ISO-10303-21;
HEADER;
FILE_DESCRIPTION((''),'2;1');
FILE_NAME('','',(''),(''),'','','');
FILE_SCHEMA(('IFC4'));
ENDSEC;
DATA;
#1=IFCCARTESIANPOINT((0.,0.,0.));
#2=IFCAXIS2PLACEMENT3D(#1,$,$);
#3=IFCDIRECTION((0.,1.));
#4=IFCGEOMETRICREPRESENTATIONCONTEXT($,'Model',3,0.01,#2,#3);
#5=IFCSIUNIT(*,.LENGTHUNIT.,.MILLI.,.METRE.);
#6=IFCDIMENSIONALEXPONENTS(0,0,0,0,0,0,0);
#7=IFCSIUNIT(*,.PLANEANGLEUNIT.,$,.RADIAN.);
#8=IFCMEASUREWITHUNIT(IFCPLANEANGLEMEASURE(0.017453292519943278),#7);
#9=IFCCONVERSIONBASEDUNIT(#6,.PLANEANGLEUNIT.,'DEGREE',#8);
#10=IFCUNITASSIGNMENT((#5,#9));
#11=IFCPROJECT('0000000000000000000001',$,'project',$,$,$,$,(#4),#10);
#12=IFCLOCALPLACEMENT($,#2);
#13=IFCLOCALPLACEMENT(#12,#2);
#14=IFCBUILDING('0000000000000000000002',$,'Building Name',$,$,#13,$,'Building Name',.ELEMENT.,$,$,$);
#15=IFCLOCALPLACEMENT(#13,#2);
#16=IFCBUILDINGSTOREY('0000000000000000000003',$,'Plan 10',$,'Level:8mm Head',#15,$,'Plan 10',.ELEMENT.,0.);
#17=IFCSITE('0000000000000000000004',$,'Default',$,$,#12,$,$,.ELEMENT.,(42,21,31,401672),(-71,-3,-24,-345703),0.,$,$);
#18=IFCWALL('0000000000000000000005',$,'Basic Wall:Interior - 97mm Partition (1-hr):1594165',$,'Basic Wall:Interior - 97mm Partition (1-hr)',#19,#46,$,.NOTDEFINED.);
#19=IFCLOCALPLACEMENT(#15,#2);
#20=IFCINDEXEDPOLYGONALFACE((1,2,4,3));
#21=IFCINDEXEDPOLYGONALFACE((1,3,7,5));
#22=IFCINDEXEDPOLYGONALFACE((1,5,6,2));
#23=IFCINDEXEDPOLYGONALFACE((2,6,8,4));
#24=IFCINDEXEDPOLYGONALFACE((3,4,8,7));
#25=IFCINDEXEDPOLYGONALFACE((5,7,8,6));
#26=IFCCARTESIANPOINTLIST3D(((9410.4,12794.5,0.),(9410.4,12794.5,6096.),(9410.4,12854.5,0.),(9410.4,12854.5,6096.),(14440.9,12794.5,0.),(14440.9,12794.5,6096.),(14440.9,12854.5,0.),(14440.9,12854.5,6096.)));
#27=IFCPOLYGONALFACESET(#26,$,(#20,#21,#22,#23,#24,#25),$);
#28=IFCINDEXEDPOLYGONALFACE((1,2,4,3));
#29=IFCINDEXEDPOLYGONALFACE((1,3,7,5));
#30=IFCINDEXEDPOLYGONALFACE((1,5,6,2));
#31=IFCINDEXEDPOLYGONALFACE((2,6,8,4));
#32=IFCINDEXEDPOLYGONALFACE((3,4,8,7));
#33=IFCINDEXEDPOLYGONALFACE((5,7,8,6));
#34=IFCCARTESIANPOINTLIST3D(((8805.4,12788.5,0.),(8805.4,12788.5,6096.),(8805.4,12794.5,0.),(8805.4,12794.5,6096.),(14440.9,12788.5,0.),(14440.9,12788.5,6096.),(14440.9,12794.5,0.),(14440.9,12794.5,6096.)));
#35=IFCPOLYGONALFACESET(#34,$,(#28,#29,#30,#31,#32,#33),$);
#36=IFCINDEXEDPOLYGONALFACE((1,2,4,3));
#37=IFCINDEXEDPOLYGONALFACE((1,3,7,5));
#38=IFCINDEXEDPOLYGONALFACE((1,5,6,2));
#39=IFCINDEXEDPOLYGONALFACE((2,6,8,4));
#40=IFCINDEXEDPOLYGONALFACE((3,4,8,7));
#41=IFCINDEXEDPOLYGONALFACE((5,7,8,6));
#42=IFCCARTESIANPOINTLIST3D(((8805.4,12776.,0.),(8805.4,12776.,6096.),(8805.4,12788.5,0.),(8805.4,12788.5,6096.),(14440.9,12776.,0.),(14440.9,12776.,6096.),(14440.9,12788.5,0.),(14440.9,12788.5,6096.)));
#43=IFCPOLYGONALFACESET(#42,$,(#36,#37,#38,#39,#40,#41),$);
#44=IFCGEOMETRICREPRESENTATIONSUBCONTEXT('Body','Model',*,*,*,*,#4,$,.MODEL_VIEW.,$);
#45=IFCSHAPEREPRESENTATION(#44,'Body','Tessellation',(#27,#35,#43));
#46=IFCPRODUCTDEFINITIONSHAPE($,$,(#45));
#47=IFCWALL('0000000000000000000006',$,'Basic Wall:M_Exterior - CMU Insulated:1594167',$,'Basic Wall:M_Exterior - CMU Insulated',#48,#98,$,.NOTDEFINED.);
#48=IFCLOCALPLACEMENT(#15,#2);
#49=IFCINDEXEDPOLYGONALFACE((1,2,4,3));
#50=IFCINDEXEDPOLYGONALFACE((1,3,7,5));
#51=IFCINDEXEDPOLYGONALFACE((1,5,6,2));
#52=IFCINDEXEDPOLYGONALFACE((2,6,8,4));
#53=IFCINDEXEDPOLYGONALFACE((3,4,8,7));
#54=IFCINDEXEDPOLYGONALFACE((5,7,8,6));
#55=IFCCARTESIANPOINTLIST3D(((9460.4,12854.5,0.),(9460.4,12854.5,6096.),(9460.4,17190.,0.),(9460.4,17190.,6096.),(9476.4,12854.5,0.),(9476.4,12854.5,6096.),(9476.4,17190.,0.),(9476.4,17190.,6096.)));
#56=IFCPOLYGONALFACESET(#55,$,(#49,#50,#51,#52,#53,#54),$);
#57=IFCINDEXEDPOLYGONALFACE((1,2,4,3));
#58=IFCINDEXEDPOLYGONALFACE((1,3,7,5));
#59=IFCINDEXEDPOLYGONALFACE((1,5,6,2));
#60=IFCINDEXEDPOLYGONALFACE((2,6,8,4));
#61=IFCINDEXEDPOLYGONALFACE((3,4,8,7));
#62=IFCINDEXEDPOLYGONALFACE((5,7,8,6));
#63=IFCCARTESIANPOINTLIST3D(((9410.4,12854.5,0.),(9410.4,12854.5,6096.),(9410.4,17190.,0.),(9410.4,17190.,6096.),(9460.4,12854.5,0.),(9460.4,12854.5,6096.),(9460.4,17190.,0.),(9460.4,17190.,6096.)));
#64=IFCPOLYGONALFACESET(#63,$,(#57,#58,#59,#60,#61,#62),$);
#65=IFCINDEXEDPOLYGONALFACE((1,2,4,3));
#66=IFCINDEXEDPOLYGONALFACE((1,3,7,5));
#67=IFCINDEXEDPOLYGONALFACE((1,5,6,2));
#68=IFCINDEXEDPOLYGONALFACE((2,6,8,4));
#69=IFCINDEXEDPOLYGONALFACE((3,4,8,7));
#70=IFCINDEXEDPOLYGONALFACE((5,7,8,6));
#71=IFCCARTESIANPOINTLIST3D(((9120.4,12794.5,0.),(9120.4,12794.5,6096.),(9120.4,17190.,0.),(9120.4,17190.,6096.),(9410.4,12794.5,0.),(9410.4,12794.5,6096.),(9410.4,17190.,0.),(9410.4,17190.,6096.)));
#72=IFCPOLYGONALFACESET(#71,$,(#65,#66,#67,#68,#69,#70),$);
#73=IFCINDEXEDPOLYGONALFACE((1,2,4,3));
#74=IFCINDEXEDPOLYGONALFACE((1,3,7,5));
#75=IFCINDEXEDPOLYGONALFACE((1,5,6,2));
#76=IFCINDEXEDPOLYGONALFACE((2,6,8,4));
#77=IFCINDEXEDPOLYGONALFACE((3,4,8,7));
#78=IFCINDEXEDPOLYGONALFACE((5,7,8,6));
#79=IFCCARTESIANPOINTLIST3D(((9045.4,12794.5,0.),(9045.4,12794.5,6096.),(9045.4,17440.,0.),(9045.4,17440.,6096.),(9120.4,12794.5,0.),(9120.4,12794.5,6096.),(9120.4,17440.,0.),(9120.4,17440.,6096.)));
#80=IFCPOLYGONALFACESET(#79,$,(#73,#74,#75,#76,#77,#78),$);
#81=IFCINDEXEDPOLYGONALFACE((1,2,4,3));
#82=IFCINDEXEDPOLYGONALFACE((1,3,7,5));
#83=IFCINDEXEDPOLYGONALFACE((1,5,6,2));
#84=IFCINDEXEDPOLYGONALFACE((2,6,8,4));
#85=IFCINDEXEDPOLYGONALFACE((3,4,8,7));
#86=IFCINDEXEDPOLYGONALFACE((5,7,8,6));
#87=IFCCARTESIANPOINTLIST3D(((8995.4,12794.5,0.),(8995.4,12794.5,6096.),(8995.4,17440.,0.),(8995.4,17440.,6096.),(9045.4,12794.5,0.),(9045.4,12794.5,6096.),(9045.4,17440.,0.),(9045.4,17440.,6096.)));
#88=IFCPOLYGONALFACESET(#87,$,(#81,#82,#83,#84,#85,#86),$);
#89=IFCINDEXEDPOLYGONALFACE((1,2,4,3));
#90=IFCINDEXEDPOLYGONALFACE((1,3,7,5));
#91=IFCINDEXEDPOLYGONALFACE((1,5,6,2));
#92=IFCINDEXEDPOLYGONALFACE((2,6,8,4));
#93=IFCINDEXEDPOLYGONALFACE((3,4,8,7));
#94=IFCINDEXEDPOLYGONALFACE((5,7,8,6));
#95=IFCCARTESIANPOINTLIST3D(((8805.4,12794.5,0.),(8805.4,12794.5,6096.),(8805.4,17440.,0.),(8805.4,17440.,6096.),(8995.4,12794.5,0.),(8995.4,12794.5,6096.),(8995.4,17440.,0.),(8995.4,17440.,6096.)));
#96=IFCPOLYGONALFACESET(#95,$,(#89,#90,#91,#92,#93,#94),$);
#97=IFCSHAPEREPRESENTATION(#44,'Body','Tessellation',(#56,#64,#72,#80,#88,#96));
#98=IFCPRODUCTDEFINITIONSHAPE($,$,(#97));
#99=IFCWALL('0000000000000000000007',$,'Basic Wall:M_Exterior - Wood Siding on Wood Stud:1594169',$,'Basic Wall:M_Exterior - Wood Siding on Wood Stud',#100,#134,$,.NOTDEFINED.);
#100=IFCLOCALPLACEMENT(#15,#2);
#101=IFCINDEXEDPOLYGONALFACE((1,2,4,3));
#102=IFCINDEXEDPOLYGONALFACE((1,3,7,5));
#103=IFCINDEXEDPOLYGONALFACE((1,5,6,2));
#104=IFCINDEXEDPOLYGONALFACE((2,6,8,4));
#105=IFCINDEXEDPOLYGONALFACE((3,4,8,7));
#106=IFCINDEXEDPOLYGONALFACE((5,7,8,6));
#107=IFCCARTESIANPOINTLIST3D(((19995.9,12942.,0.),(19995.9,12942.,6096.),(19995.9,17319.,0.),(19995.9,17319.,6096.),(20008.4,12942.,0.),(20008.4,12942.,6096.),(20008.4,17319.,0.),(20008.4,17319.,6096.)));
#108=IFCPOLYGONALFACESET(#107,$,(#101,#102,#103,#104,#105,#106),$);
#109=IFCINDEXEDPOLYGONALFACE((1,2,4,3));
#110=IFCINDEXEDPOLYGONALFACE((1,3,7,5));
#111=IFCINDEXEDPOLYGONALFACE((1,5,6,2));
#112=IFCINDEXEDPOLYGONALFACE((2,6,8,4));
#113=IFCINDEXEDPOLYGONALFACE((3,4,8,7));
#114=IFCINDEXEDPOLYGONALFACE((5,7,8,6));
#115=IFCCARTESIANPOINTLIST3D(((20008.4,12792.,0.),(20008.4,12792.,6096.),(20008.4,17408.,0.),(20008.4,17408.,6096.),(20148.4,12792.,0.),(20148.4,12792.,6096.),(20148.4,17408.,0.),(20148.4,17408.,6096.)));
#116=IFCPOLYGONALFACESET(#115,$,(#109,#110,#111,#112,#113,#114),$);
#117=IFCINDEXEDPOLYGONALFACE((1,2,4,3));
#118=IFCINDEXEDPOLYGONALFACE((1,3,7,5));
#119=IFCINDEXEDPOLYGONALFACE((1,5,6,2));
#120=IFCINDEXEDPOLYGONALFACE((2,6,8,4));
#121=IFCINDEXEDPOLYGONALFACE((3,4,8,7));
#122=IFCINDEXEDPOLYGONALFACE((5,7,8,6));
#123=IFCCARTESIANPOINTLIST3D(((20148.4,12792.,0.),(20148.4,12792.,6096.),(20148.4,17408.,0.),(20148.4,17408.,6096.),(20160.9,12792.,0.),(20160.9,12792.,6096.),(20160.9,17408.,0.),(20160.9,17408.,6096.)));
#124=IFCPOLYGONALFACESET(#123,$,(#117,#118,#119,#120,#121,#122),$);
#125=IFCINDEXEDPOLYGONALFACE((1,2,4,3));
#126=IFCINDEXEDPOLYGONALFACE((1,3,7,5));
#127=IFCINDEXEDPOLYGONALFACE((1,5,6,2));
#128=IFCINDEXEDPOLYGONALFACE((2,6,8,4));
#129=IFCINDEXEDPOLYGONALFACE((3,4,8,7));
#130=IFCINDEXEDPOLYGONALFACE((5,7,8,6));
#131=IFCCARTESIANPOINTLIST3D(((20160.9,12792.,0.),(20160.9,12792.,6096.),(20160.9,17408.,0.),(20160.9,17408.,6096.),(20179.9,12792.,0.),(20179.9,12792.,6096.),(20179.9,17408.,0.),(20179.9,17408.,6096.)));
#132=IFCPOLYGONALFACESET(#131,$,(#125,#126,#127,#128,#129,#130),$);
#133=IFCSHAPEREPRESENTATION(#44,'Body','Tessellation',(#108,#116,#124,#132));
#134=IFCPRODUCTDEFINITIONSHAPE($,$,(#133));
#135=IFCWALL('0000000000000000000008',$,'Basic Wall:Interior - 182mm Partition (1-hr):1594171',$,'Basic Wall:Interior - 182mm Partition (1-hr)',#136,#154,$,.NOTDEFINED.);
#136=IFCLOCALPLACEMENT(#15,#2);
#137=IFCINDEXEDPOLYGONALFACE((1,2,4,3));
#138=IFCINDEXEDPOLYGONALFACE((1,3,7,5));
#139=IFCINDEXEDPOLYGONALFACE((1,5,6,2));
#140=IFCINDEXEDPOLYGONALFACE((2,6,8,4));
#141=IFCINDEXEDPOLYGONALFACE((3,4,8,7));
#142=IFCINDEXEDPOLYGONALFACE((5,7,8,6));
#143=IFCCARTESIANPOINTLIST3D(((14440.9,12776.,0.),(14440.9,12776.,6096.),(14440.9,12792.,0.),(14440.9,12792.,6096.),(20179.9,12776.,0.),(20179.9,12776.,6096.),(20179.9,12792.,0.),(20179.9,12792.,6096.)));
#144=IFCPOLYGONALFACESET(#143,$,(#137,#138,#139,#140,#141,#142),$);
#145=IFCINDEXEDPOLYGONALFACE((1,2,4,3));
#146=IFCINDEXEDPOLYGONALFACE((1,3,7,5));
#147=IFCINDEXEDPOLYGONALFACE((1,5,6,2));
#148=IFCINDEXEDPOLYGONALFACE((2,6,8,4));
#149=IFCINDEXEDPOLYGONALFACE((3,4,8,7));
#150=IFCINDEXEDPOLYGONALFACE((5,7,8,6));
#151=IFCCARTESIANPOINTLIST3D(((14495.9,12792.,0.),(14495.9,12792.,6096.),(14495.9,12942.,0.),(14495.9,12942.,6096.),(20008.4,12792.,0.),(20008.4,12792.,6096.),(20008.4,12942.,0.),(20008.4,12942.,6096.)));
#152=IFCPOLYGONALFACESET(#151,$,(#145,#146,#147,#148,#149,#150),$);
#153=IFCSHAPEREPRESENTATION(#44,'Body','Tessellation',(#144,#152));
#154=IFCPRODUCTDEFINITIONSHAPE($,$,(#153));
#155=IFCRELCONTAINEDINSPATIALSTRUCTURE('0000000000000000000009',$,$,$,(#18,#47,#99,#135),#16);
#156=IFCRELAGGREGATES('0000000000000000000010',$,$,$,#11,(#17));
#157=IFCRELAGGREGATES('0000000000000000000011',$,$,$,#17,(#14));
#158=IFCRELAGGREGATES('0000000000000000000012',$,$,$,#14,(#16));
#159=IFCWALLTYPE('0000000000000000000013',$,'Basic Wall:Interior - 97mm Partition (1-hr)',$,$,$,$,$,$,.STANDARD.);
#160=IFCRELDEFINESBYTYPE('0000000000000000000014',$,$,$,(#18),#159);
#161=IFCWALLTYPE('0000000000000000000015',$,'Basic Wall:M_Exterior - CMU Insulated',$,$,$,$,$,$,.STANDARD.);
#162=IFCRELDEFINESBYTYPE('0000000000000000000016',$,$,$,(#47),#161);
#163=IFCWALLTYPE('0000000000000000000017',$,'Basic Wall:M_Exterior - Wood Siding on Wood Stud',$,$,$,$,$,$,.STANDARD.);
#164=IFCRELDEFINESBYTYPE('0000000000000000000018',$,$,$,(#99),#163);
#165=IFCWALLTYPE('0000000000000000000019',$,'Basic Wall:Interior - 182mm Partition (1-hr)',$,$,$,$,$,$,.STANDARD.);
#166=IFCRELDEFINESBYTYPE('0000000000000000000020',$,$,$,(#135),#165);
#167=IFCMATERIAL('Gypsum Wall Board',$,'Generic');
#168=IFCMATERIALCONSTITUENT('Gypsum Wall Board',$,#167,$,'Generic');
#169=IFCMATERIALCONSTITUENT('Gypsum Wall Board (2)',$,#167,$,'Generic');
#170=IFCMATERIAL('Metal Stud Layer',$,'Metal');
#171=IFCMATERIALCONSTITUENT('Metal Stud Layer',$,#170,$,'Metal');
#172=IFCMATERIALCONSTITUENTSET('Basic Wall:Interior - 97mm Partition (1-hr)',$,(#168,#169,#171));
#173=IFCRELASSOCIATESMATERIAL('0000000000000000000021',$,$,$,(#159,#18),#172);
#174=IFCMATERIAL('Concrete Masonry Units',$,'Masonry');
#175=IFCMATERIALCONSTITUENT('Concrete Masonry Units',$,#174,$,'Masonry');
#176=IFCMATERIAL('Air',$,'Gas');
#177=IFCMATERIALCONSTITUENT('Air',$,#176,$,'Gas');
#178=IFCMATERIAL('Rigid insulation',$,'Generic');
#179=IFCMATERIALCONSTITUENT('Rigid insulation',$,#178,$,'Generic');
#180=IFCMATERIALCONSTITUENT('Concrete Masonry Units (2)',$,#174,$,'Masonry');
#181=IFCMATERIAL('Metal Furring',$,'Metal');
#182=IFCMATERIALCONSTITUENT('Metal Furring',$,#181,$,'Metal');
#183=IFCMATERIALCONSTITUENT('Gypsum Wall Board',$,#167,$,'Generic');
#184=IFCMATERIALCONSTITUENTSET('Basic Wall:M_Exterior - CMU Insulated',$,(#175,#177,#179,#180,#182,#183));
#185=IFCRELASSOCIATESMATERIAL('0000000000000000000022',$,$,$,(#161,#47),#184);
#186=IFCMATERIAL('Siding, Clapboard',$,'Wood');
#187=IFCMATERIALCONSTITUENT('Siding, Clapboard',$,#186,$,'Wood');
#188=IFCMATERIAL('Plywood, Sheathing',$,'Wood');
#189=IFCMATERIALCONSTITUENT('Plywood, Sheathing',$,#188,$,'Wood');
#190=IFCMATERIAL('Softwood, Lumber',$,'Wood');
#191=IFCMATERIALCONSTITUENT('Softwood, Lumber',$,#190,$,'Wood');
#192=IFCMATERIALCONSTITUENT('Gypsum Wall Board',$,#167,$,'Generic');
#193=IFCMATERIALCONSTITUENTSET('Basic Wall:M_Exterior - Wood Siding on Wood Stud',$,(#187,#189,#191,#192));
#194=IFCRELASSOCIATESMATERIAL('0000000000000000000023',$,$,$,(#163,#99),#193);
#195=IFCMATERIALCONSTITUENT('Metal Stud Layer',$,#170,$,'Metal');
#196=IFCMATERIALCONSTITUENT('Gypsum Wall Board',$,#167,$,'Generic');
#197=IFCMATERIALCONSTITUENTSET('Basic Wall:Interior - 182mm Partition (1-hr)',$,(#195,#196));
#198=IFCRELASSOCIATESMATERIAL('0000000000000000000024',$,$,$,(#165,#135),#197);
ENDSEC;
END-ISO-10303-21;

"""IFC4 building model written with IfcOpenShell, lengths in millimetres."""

from ifc_helpers import new_model, entity, si_unit, converted_unit, direction, frame, origin, place, context, subcontext, project, spatial, indexed_curve, outline, extrude, material, constituent, constituent_set, type_object, element, save


model = new_model("IFC4")

# Units and contexts
model_context = context("Model", 3, precision=0.01, world=origin(), true_north=direction((0.0, 1.0)))
body_context = subcontext(model_context, "Body", "Model", "MODEL_VIEW")
ifc_project = project(units=[si_unit("LENGTHUNIT", "METRE", prefix="MILLI"), converted_unit("PLANEANGLEUNIT", "DEGREE", entity("IfcPlaneAngleMeasure", 0.017453292519943278), si_unit("PLANEANGLEUNIT", "RADIAN"), dimensions=[0, 0, 0, 0, 0, 0, 0])], contexts=[model_context])

# Site, building, storey
site_placement = place(None, origin())
site = spatial("IfcSite", under=ifc_project, at=site_placement, Name="Default", CompositionType="ELEMENT", RefLatitude=(42, 21, 31, 401672), RefLongitude=(-71, -3, -24, -345703), RefElevation=0.0)
building_placement = place(site_placement, origin())
building = spatial("IfcBuilding", under=site, at=building_placement, Name="Building Name", LongName="Building Name", CompositionType="ELEMENT")
storey_placement = place(building_placement, origin())
storey = spatial("IfcBuildingStorey", under=building, at=storey_placement, Name="Plan 10", ObjectType="Level:8mm Head", LongName="Plan 10", CompositionType="ELEMENT", Elevation=0.0)

# Walls
ifc_material_1 = material(Name="Concrete Masonry Units", Category="Masonry")
ifc_material_2 = material(Name="Gypsum Wall Board", Category="Generic")
ifc_constituent_1 = constituent(ifc_material_2, Name="Gypsum Wall Board", Category="Generic")
ifc_constituent_2 = constituent(ifc_material_2, Name="Gypsum Wall Board (2)", Category="Generic")
ifc_material_3 = material(Name="Metal Stud Layer", Category="Metal")
ifc_constituent_3 = constituent(ifc_material_3, Name="Metal Stud Layer", Category="Metal")
ifc_constituent_set_1 = constituent_set(constituents=[ifc_constituent_1, ifc_constituent_2, ifc_constituent_3], Name="Basic Wall:Interior - 97mm Partition (1-hr)")
wall_type_1 = type_object("IfcWallType", Name="Basic Wall:Interior - 97mm Partition (1-hr)", PredefinedType="STANDARD", material=ifc_constituent_set_1)
wall_1_placement = place(storey_placement, frame((14440.9, 12815.3, 0.0), z_axis=(0.0, 0.0, 1.0), x_axis=(-1.0, 0.0, 0.0)))
element("IfcWall", 1, at=wall_1_placement, inside=storey, type_object=wall_type_1, material=ifc_constituent_set_1, Name="Basic Wall:Interior - 97mm Partition (1-hr):1594165", ObjectType="Basic Wall:Interior - 97mm Partition (1-hr)", PredefinedType="NOTDEFINED", context=body_context, shape_type="SweptSolid", body=[
    extrude(outline(indexed_curve([(-30.0, -2515.2), (30.0, -2515.2), (30.0, 2515.2), (-30.0, 2515.2), (-30.0, -2515.2)], self_intersect=False)), frame((2515.2, -9.2, 0.0), z_axis=(0.0, 0.0, 1.0), x_axis=(0.0, 1.0, 0.0)), (0.0, 0.0, 1.0), 6096.0),
    extrude(outline(indexed_curve([(-2817.7, -3.0), (2817.7, -3.0), (2817.7, 3.0), (-2817.7, 3.0), (-2817.7, -3.0)], self_intersect=False)), frame((2817.7, 23.8, 0.0)), (0.0, 0.0, 1.0), 6096.0),
    extrude(outline(indexed_curve([(-6.3, -2817.7), (6.2, -2817.7), (6.3, 2817.7), (-6.2, 2817.7), (-6.3, -2817.7)], self_intersect=False)), frame((2817.7, 33.0, 0.0), z_axis=(0.0, 0.0, 1.0), x_axis=(0.0, -1.0, 0.0)), (0.0, 0.0, 1.0), 6096.0),
])
ifc_constituent_4 = constituent(ifc_material_1, Name="Concrete Masonry Units", Category="Masonry")
ifc_material_4 = material(Name="Air", Category="Gas")
ifc_constituent_5 = constituent(ifc_material_4, Name="Air", Category="Gas")
ifc_material_5 = material(Name="Rigid insulation", Category="Generic")
ifc_constituent_6 = constituent(ifc_material_5, Name="Rigid insulation", Category="Generic")
ifc_constituent_7 = constituent(ifc_material_1, Name="Concrete Masonry Units (2)", Category="Masonry")
ifc_material_6 = material(Name="Metal Furring", Category="Metal")
ifc_constituent_8 = constituent(ifc_material_6, Name="Metal Furring", Category="Metal")
ifc_constituent_9 = constituent(ifc_material_2, Name="Gypsum Wall Board", Category="Generic")
ifc_constituent_set_2 = constituent_set(constituents=[ifc_constituent_4, ifc_constituent_5, ifc_constituent_6, ifc_constituent_7, ifc_constituent_8, ifc_constituent_9], Name="Basic Wall:M_Exterior - CMU Insulated")
wall_type_2 = type_object("IfcWallType", Name="Basic Wall:M_Exterior - CMU Insulated", PredefinedType="STANDARD", material=ifc_constituent_set_2)
wall_2_placement = place(storey_placement, frame((9140.9, 12776.0, 0.0), z_axis=(0.0, 0.0, 1.0), x_axis=(0.0, 1.0, 0.0)))
element("IfcWall", 2, at=wall_2_placement, inside=storey, type_object=wall_type_2, material=ifc_constituent_set_2, Name="Basic Wall:M_Exterior - CMU Insulated:1594167", ObjectType="Basic Wall:M_Exterior - CMU Insulated", PredefinedType="NOTDEFINED", context=body_context, shape_type="SweptSolid", body=[
    extrude(outline(indexed_curve([(-2167.8, -8.0), (2167.8, -8.0), (2167.8, 8.0), (-2167.8, 8.0), (-2167.8, -8.0)], self_intersect=False)), frame((2246.3, -327.5, 0.0)), (0.0, 0.0, 1.0), 6096.0),
    extrude(outline(indexed_curve([(-2167.8, -25.0), (2167.8, -25.0), (2167.8, 25.0), (-2167.8, 25.0), (-2167.8, -25.0)], self_intersect=False)), frame((2246.3, -294.5, 0.0)), (0.0, 0.0, 1.0), 6096.0),
    extrude(outline(indexed_curve([(-2197.8, -145.0), (2197.8, -145.0), (2197.8, 145.0), (-2197.8, 145.0), (-2197.8, -145.0)], self_intersect=False)), frame((2216.3, -124.5, 0.0)), (0.0, 0.0, 1.0), 6096.0),
    extrude(outline(indexed_curve([(-2322.8, -37.5), (2322.8, -37.5), (2322.8, 37.5), (-2322.8, 37.5), (-2322.8, -37.5)], self_intersect=False)), frame((2341.3, 58.0, 0.0)), (0.0, 0.0, 1.0), 6096.0),
    extrude(outline(indexed_curve([(-2322.8, -25.0), (2322.8, -25.0), (2322.8, 25.0), (-2322.8, 25.0), (-2322.8, -25.0)], self_intersect=False)), frame((2341.3, 120.5, 0.0)), (0.0, 0.0, 1.0), 6096.0),
    extrude(outline(indexed_curve([(-95.0, -2322.8), (95.0, -2322.8), (95.0, 2322.8), (-95.0, 2322.8), (-95.0, -2322.8)], self_intersect=False)), frame((2341.3, 240.5, 0.0), z_axis=(0.0, 0.0, 1.0), x_axis=(0.0, -1.0, 0.0)), (0.0, 0.0, 1.0), 6096.0),
])
ifc_material_7 = material(Name="Siding, Clapboard", Category="Wood")
ifc_constituent_10 = constituent(ifc_material_7, Name="Siding, Clapboard", Category="Wood")
ifc_material_8 = material(Name="Plywood, Sheathing", Category="Wood")
ifc_constituent_11 = constituent(ifc_material_8, Name="Plywood, Sheathing", Category="Wood")
ifc_material_9 = material(Name="Softwood, Lumber", Category="Wood")
ifc_constituent_12 = constituent(ifc_material_9, Name="Softwood, Lumber", Category="Wood")
ifc_constituent_13 = constituent(ifc_material_2, Name="Gypsum Wall Board", Category="Generic")
ifc_constituent_set_3 = constituent_set(constituents=[ifc_constituent_10, ifc_constituent_11, ifc_constituent_12, ifc_constituent_13], Name="Basic Wall:M_Exterior - Wood Siding on Wood Stud")
wall_type_3 = type_object("IfcWallType", Name="Basic Wall:M_Exterior - Wood Siding on Wood Stud", PredefinedType="STANDARD", material=ifc_constituent_set_3)
wall_3_placement = place(storey_placement, frame((20087.9, 17440.0, 0.0), z_axis=(0.0, 0.0, 1.0), x_axis=(0.0, -1.0, 0.0)))
element("IfcWall", 3, at=wall_3_placement, inside=storey, type_object=wall_type_3, material=ifc_constituent_set_3, Name="Basic Wall:M_Exterior - Wood Siding on Wood Stud:1594169", ObjectType="Basic Wall:M_Exterior - Wood Siding on Wood Stud", PredefinedType="NOTDEFINED", context=body_context, shape_type="SweptSolid", body=[
    extrude(outline(indexed_curve([(-2188.5, -6.2), (2188.5, -6.3), (2188.5, 6.2), (-2188.5, 6.3), (-2188.5, -6.2)], self_intersect=False)), frame((2309.5, -85.7, 0.0)), (0.0, 0.0, 1.0), 6096.0),
    extrude(outline(indexed_curve([(-2308.0, -70.0), (2308.0, -70.0), (2308.0, 70.0), (-2308.0, 70.0), (-2308.0, -70.0)], self_intersect=False)), frame((2340.0, -9.5, 0.0)), (0.0, 0.0, 1.0), 6096.0),
    extrude(outline(indexed_curve([(-2308.0, -6.2), (2308.0, -6.3), (2308.0, 6.2), (-2308.0, 6.3), (-2308.0, -6.2)], self_intersect=False)), frame((2340.0, 66.8, 0.0)), (0.0, 0.0, 1.0), 6096.0),
    extrude(outline(indexed_curve([(-9.5, -2308.0), (9.5, -2308.0), (9.5, 2308.0), (-9.5, 2308.0), (-9.5, -2308.0)], self_intersect=False)), frame((2340.0, 82.5, 0.0), z_axis=(0.0, 0.0, 1.0), x_axis=(0.0, -1.0, 0.0)), (0.0, 0.0, 1.0), 6096.0),
])
ifc_constituent_14 = constituent(ifc_material_3, Name="Metal Stud Layer", Category="Metal")
ifc_constituent_15 = constituent(ifc_material_2, Name="Gypsum Wall Board", Category="Generic")
ifc_constituent_set_4 = constituent_set(constituents=[ifc_constituent_14, ifc_constituent_15], Name="Basic Wall:Interior - 182mm Partition (1-hr)")
wall_type_4 = type_object("IfcWallType", Name="Basic Wall:Interior - 182mm Partition (1-hr)", PredefinedType="STANDARD", material=ifc_constituent_set_4)
wall_4_placement = place(storey_placement, frame((14695.9, 12859.0, 0.0)))
element("IfcWall", 4, at=wall_4_placement, inside=storey, type_object=wall_type_4, material=ifc_constituent_set_4, Name="Basic Wall:Interior - 182mm Partition (1-hr):1594171", ObjectType="Basic Wall:Interior - 182mm Partition (1-hr)", PredefinedType="NOTDEFINED", context=body_context, shape_type="SweptSolid", body=[
    extrude(outline(indexed_curve([(-8.0, -2869.5), (8.0, -2869.5), (8.0, 2869.5), (-8.0, 2869.5), (-8.0, -2869.5)], self_intersect=False)), frame((2614.5, -75.0, 0.0), z_axis=(0.0, 0.0, 1.0), x_axis=(0.0, 1.0, 0.0)), (0.0, 0.0, 1.0), 6096.0),
    extrude(outline(indexed_curve([(-75.0, -2756.2), (75.0, -2756.2), (75.0, 2756.2), (-75.0, 2756.2), (-75.0, -2756.2)], self_intersect=False)), frame((2556.2, 8.0, 0.0), z_axis=(0.0, 0.0, 1.0), x_axis=(0.0, -1.0, 0.0)), (0.0, 0.0, 1.0), 6096.0),
])

save(model, "model.ifc")
